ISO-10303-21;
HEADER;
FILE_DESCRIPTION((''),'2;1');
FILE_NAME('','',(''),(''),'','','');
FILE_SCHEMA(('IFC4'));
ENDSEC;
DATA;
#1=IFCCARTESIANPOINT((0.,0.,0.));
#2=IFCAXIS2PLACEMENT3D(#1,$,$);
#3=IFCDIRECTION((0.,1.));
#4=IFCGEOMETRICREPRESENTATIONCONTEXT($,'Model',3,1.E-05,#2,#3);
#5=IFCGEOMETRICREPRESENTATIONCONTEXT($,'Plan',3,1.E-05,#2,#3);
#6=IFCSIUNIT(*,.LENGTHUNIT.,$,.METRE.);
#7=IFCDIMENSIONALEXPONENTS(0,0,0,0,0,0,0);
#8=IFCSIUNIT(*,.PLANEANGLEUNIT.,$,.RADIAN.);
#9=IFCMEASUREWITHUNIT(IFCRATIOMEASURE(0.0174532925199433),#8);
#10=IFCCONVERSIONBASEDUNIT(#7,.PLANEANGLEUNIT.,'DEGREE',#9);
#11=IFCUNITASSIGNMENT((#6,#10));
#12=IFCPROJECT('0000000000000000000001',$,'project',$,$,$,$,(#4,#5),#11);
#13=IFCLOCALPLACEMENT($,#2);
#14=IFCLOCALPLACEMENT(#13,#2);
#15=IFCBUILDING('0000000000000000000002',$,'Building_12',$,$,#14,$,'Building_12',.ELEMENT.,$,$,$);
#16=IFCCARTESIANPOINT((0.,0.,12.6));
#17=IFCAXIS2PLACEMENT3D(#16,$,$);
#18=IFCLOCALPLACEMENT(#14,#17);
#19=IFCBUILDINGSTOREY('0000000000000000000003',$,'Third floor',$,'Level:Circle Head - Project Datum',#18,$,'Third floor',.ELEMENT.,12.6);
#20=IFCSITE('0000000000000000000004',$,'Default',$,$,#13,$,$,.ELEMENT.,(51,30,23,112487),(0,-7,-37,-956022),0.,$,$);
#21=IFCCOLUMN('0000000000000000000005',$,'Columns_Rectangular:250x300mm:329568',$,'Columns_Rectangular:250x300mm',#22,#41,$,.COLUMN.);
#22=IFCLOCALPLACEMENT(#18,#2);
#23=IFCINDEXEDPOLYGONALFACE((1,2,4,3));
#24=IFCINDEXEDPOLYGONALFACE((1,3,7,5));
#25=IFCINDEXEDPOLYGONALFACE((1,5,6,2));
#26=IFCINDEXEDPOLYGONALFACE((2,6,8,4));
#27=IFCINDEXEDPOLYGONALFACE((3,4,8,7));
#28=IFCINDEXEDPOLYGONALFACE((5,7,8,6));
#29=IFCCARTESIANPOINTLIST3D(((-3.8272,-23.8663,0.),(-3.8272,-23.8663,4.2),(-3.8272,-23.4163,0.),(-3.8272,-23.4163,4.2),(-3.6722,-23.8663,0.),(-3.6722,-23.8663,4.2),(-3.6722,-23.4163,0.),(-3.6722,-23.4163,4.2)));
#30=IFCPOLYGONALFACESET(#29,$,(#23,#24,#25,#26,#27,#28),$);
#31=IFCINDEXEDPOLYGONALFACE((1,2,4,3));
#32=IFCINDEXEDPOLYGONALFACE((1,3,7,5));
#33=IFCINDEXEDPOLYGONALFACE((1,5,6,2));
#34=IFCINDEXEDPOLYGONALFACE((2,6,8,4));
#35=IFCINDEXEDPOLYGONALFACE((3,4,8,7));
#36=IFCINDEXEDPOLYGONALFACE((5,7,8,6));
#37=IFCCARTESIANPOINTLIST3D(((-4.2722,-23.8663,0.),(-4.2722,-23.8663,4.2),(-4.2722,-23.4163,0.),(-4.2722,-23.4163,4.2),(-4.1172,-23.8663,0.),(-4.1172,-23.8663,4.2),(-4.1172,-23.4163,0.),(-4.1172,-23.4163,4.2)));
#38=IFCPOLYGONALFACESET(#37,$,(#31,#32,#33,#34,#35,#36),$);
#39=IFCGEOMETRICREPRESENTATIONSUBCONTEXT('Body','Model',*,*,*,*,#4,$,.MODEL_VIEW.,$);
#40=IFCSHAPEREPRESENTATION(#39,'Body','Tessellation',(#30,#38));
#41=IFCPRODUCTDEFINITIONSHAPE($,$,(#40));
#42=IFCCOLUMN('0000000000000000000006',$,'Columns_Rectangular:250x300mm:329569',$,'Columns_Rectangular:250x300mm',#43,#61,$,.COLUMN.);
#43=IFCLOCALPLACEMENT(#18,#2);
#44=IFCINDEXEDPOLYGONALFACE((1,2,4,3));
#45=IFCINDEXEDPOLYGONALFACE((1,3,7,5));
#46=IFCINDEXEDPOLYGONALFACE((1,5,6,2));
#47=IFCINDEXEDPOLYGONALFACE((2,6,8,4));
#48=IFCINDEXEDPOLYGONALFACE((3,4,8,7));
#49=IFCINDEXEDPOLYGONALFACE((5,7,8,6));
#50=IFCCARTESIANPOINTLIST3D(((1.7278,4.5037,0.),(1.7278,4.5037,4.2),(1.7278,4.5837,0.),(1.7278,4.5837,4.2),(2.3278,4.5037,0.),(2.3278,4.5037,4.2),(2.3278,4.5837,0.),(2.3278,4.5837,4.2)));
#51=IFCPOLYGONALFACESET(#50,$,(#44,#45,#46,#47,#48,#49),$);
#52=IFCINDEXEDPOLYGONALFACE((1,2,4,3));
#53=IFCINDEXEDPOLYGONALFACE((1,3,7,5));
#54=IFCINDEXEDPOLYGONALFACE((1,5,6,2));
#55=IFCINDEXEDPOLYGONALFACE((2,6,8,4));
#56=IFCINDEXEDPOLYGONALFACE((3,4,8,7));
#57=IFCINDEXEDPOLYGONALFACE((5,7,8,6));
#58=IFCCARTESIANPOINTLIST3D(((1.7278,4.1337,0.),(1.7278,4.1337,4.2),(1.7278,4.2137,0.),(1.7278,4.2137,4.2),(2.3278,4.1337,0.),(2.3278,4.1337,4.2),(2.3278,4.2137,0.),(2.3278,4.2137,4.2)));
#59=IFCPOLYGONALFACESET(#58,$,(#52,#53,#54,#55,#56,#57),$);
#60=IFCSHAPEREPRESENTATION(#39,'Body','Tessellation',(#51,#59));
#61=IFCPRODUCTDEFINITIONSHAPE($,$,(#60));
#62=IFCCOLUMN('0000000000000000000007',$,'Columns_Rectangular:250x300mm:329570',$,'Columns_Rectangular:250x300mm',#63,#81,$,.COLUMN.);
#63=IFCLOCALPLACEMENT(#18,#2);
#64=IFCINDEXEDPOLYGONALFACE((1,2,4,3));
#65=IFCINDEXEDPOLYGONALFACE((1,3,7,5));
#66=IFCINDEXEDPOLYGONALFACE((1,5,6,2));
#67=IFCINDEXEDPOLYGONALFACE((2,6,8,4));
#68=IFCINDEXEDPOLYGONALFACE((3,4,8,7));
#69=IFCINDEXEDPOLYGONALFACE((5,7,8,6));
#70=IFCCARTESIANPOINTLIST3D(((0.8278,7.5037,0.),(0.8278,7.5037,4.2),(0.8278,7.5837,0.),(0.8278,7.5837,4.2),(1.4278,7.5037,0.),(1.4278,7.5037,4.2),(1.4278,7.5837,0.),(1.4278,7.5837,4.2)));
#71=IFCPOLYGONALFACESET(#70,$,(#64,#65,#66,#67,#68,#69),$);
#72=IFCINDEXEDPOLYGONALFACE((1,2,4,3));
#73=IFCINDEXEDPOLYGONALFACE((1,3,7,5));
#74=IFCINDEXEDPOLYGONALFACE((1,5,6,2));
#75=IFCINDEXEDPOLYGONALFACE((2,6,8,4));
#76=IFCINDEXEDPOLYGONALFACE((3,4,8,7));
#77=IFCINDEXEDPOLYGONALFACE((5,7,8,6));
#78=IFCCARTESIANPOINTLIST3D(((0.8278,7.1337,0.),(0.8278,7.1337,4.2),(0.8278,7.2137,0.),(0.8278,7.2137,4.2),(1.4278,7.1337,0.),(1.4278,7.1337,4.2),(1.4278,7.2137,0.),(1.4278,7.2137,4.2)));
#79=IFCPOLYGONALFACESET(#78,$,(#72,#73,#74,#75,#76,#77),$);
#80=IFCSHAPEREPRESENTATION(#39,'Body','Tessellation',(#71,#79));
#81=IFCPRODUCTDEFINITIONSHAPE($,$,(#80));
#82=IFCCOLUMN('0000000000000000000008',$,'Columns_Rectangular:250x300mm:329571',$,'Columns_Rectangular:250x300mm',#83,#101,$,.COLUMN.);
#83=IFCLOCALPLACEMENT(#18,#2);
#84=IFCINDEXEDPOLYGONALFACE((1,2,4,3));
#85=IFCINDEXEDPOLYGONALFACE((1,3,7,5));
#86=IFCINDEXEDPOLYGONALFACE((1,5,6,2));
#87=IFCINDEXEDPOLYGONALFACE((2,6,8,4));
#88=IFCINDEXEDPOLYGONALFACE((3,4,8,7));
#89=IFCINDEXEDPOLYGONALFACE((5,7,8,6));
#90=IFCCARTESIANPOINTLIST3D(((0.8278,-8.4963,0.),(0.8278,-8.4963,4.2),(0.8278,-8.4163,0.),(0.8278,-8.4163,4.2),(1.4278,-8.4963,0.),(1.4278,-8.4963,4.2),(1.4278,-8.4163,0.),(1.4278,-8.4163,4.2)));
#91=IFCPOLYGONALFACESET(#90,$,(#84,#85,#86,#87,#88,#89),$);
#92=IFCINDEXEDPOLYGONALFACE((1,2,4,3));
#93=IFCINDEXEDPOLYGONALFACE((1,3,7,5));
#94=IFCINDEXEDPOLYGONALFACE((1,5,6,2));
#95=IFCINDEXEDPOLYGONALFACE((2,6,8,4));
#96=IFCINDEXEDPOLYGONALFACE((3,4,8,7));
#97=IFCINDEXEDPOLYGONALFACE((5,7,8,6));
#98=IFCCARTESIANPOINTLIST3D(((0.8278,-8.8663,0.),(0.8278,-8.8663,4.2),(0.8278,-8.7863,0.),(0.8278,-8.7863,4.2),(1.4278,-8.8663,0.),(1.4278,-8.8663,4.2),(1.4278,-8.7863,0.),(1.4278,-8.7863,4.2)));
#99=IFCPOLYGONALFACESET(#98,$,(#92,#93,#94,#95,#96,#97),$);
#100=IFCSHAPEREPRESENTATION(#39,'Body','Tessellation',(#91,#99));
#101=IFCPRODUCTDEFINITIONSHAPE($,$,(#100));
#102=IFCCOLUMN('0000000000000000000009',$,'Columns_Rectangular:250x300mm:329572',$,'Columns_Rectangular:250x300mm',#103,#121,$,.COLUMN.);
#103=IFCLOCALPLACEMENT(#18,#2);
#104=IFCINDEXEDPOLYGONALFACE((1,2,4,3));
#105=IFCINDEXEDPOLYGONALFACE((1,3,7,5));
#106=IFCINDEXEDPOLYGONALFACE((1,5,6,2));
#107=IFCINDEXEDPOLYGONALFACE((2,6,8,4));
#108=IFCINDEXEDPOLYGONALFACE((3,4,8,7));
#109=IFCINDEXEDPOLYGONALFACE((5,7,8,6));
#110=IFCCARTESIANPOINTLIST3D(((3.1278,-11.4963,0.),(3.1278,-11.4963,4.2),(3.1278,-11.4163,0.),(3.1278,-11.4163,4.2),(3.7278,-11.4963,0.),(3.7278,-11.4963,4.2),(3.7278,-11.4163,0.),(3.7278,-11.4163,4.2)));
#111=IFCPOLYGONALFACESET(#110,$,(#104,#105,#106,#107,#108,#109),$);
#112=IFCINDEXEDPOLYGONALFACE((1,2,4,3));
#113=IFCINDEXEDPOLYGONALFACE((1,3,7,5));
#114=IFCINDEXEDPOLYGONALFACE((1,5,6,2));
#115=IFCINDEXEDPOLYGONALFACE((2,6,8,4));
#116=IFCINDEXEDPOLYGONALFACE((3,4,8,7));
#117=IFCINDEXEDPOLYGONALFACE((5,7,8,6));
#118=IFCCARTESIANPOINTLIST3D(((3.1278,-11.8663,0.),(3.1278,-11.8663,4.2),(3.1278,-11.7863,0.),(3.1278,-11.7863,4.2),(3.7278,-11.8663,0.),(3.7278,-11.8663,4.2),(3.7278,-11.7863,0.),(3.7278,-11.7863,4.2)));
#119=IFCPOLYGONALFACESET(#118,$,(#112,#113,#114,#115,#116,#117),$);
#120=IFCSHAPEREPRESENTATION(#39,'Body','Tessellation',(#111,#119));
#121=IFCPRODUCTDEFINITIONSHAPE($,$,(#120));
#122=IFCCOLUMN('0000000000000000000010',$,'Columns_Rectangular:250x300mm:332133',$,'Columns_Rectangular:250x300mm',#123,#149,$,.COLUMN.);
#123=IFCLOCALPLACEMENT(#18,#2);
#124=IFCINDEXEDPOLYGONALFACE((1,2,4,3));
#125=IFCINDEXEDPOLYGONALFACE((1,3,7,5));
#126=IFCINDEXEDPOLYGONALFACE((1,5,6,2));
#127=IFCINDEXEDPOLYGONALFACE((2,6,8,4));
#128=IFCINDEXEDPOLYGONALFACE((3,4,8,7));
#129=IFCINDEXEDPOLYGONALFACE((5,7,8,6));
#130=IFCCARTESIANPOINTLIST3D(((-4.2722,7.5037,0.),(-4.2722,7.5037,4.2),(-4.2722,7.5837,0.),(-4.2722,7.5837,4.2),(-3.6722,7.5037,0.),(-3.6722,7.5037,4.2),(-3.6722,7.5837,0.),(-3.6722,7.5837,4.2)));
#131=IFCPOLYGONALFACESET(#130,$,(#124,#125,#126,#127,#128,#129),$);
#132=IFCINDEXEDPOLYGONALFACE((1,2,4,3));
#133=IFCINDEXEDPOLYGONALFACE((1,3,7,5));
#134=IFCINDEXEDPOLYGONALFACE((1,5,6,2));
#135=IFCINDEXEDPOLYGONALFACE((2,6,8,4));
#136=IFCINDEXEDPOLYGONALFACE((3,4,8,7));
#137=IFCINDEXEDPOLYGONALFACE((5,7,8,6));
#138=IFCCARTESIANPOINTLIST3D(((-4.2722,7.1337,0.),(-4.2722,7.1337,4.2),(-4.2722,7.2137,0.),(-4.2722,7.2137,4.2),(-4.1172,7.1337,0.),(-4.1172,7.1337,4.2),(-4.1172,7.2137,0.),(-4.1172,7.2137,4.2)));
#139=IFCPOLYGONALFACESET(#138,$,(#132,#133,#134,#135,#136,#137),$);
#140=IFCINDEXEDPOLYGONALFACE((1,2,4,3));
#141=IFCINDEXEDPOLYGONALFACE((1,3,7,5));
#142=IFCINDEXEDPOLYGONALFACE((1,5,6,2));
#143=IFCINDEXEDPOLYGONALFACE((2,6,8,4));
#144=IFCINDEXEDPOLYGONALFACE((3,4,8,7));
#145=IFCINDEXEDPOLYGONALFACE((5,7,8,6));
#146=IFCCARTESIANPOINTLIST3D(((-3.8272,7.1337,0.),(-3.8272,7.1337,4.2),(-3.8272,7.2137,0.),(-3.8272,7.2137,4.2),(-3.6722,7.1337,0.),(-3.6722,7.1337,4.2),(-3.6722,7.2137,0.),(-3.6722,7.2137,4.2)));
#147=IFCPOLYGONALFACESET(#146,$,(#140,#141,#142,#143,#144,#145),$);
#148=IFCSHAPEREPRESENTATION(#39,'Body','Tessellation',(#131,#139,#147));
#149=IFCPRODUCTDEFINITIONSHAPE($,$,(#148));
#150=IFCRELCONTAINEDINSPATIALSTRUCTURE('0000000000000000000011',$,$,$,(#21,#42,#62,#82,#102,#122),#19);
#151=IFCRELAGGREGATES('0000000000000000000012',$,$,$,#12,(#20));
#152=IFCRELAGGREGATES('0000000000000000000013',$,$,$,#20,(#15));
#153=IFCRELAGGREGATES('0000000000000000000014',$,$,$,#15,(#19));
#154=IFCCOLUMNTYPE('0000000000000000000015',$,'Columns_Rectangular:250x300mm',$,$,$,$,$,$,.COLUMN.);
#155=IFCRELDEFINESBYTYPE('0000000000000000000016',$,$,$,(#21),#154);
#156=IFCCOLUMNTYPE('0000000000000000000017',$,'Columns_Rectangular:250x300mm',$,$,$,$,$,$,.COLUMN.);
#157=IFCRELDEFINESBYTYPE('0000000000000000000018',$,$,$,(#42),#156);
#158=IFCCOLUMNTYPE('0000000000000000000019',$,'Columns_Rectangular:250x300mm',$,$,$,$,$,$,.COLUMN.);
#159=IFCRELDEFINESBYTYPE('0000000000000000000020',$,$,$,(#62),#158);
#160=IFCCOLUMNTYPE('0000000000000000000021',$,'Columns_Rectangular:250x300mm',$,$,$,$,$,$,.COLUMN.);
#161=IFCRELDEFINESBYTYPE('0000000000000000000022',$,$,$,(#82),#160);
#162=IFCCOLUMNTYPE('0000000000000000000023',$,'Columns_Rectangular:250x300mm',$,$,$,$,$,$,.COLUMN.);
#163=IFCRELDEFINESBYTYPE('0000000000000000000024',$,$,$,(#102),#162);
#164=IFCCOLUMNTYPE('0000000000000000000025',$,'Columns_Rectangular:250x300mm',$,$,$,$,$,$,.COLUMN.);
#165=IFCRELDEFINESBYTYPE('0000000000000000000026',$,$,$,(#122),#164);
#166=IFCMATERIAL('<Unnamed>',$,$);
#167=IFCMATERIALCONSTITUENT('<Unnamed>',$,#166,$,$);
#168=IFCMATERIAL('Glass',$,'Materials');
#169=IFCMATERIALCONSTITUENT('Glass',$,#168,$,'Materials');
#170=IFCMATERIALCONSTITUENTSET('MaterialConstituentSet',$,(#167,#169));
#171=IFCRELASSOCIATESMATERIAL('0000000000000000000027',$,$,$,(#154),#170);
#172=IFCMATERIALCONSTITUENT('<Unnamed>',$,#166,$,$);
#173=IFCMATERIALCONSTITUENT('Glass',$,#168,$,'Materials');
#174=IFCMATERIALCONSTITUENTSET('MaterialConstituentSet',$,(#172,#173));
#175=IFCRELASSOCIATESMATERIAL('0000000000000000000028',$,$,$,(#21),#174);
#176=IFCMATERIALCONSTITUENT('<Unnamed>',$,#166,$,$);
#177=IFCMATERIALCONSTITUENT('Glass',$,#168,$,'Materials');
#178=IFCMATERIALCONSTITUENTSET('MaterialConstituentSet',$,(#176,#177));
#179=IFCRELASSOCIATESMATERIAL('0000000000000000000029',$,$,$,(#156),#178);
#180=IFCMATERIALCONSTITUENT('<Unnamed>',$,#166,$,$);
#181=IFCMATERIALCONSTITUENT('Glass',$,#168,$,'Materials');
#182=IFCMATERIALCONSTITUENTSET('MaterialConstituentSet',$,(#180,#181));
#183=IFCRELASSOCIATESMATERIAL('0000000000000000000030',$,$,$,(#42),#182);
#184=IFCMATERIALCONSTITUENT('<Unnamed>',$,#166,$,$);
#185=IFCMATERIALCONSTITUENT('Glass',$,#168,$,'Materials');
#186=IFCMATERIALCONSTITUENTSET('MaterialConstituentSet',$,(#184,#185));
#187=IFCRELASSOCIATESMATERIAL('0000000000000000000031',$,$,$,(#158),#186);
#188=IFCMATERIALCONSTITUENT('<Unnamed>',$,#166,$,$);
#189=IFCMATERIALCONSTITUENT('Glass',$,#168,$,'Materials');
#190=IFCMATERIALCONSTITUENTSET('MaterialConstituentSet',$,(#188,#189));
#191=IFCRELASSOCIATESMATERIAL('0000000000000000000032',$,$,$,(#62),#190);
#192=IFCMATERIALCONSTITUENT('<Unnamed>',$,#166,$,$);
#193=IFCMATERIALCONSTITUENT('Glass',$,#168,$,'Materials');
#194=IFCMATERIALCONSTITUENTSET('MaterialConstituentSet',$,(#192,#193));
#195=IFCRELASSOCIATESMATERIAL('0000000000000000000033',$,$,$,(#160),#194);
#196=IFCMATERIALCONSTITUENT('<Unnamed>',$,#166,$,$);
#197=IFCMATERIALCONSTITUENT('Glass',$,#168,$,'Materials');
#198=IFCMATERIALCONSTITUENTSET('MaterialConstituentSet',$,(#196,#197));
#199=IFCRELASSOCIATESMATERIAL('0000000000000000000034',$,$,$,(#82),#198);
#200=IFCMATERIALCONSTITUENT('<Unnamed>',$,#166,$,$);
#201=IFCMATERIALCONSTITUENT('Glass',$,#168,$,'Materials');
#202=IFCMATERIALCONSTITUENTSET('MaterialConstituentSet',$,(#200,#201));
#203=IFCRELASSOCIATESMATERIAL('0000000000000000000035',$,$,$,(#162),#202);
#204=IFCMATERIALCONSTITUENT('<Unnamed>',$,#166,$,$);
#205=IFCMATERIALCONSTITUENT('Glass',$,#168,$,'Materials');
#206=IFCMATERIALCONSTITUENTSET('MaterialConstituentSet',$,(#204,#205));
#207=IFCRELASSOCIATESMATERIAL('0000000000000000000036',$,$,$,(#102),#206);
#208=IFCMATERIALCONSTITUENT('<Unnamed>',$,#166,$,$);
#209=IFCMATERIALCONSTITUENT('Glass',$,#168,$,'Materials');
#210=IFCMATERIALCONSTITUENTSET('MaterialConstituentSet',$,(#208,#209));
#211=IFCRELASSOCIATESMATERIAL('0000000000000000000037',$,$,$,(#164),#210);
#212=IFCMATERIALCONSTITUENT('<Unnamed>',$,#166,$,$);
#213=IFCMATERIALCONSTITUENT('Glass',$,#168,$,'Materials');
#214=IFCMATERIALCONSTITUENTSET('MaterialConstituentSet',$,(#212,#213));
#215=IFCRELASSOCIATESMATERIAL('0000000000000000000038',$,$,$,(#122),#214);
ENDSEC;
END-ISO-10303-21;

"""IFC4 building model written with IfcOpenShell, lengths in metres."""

from ifc_helpers import new_model, entity, si_unit, converted_unit, direction, frame, origin, place, context, subcontext, project, spatial, indexed_curve, outline, extrude, source, transform, mapped, material, constituent, constituent_set, type_object, type_shapes, element, save


model = new_model("IFC4")

# Units and contexts
model_context = context("Model", 3, precision=1e-05, world=origin(), true_north=direction((0.0, 1.0)))
plan_context = context("Plan", 3, precision=1e-05, world=origin(), true_north=direction((0.0, 1.0)))
body_context = subcontext(model_context, "Body", "Model", "MODEL_VIEW")
ifc_project = project(units=[si_unit("LENGTHUNIT", "METRE"), converted_unit("PLANEANGLEUNIT", "DEGREE", entity("IfcRatioMeasure", 0.0174532925199433), si_unit("PLANEANGLEUNIT", "RADIAN"), dimensions=[0, 0, 0, 0, 0, 0, 0])], contexts=[model_context, plan_context])

# Site, building, storey
site_placement = place(None, origin())
site = spatial("IfcSite", under=ifc_project, at=site_placement, Name="Default", CompositionType="ELEMENT", RefLatitude=(51, 30, 23, 112487), RefLongitude=(0, -7, -37, -956022), RefElevation=0.0)
building_placement = place(site_placement, origin())
building = spatial("IfcBuilding", under=site, at=building_placement, Name="Building_12", LongName="Building_12", CompositionType="ELEMENT")
storey_placement = place(building_placement, frame((0.0, 0.0, 12.6)))
storey = spatial("IfcBuildingStorey", under=building, at=storey_placement, Name="Third floor", ObjectType="Level:Circle Head - Project Datum", LongName="Third floor", CompositionType="ELEMENT", Elevation=12.6)

# Columns
ifc_material_1 = material(Name="<Unnamed>")
ifc_material_2 = material(Name="Glass", Category="Materials")
ifc_constituent_1 = constituent(ifc_material_1, Name="<Unnamed>")
ifc_constituent_2 = constituent(ifc_material_2, Name="Glass", Category="Materials")
ifc_constituent_set_1 = constituent_set(constituents=[ifc_constituent_1, ifc_constituent_2], Name="MaterialConstituentSet")
ifc_constituent_3 = constituent(ifc_material_1, Name="<Unnamed>")
ifc_constituent_4 = constituent(ifc_material_2, Name="Glass", Category="Materials")
ifc_constituent_set_2 = constituent_set(constituents=[ifc_constituent_3, ifc_constituent_4], Name="MaterialConstituentSet")
column_type_1 = type_object("IfcColumnType", Name="Columns_Rectangular:250x300mm", PredefinedType="COLUMN", material=ifc_constituent_set_2)
shared_shape_1 = source(origin(), body_context, "Body", "SweptSolid", [
    extrude(outline(indexed_curve([(-0.225, -0.0775), (0.225, -0.0775), (0.225, 0.0775), (-0.225, 0.0775), (-0.225, -0.0775)], self_intersect=False)), frame((-3.7497, -23.6413, 12.6), z_axis=(0.0, 0.0, 1.0), x_axis=(0.0, -1.0, 0.0)), (0.0, 0.0, 1.0), 4.2),
    extrude(outline(indexed_curve([(-0.225, -0.0775), (0.225, -0.0775), (0.225, 0.0775), (-0.225, 0.0775), (-0.225, -0.0775)], self_intersect=False)), frame((-4.1947, -23.6413, 12.6), z_axis=(0.0, 0.0, 1.0), x_axis=(0.0, -1.0, 0.0)), (0.0, 0.0, 1.0), 4.2),
])
type_shapes(column_type_1, [shared_shape_1])
column_1_placement = place(storey_placement, frame((0.0, 0.0, -12.6)))
element("IfcColumn", 1, at=column_1_placement, inside=storey, type_object=column_type_1, material=ifc_constituent_set_1, Name="Columns_Rectangular:250x300mm:329568", ObjectType="Columns_Rectangular:250x300mm", PredefinedType="COLUMN", context=body_context, shape_type="MappedRepresentation", body=[
    mapped(shared_shape_1, transform((0.0, 0.0, 0.0), scale=1.0)),
])
ifc_constituent_5 = constituent(ifc_material_1, Name="<Unnamed>")
ifc_constituent_6 = constituent(ifc_material_2, Name="Glass", Category="Materials")
ifc_constituent_set_3 = constituent_set(constituents=[ifc_constituent_5, ifc_constituent_6], Name="MaterialConstituentSet")
ifc_constituent_7 = constituent(ifc_material_1, Name="<Unnamed>")
ifc_constituent_8 = constituent(ifc_material_2, Name="Glass", Category="Materials")
ifc_constituent_set_4 = constituent_set(constituents=[ifc_constituent_7, ifc_constituent_8], Name="MaterialConstituentSet")
column_type_2 = type_object("IfcColumnType", Name="Columns_Rectangular:250x300mm", PredefinedType="COLUMN", material=ifc_constituent_set_4)
shared_shape_2 = source(origin(), body_context, "Body", "SweptSolid", [
    extrude(outline(indexed_curve([(-0.04, -0.3), (0.04, -0.3), (0.04, 0.3), (-0.04, 0.3), (-0.04, -0.3)], self_intersect=False)), frame((2.0278, 4.5437, 12.6), z_axis=(0.0, 0.0, 1.0), x_axis=(0.0, -1.0, 0.0)), (0.0, 0.0, 1.0), 4.2),
    extrude(outline(indexed_curve([(-0.04, -0.3), (0.04, -0.3), (0.04, 0.3), (-0.04, 0.3), (-0.04, -0.3)], self_intersect=False)), frame((2.0278, 4.1737, 12.6), z_axis=(0.0, 0.0, 1.0), x_axis=(0.0, -1.0, 0.0)), (0.0, 0.0, 1.0), 4.2),
])
type_shapes(column_type_2, [shared_shape_2])
column_2_placement = place(storey_placement, frame((0.0, 0.0, -12.6)))
element("IfcColumn", 2, at=column_2_placement, inside=storey, type_object=column_type_2, material=ifc_constituent_set_3, Name="Columns_Rectangular:250x300mm:329569", ObjectType="Columns_Rectangular:250x300mm", PredefinedType="COLUMN", context=body_context, shape_type="MappedRepresentation", body=[
    mapped(shared_shape_2, transform((0.0, 0.0, 0.0), scale=1.0)),
])
ifc_constituent_9 = constituent(ifc_material_1, Name="<Unnamed>")
ifc_constituent_10 = constituent(ifc_material_2, Name="Glass", Category="Materials")
ifc_constituent_set_5 = constituent_set(constituents=[ifc_constituent_9, ifc_constituent_10], Name="MaterialConstituentSet")
ifc_constituent_11 = constituent(ifc_material_1, Name="<Unnamed>")
ifc_constituent_12 = constituent(ifc_material_2, Name="Glass", Category="Materials")
ifc_constituent_set_6 = constituent_set(constituents=[ifc_constituent_11, ifc_constituent_12], Name="MaterialConstituentSet")
column_type_3 = type_object("IfcColumnType", Name="Columns_Rectangular:250x300mm", PredefinedType="COLUMN", material=ifc_constituent_set_6)
shared_shape_3 = source(origin(), body_context, "Body", "SweptSolid", [
    extrude(outline(indexed_curve([(-0.04, -0.3), (0.04, -0.3), (0.04, 0.3), (-0.04, 0.3), (-0.04, -0.3)], self_intersect=False)), frame((1.1278, 7.5437, 12.6), z_axis=(0.0, 0.0, 1.0), x_axis=(0.0, -1.0, 0.0)), (0.0, 0.0, 1.0), 4.2),
    extrude(outline(indexed_curve([(-0.04, -0.3), (0.04, -0.3), (0.04, 0.3), (-0.04, 0.3), (-0.04, -0.3)], self_intersect=False)), frame((1.1278, 7.1737, 12.6), z_axis=(0.0, 0.0, 1.0), x_axis=(0.0, -1.0, 0.0)), (0.0, 0.0, 1.0), 4.2),
])
type_shapes(column_type_3, [shared_shape_3])
column_3_placement = place(storey_placement, frame((0.0, 0.0, -12.6)))
element("IfcColumn", 3, at=column_3_placement, inside=storey, type_object=column_type_3, material=ifc_constituent_set_5, Name="Columns_Rectangular:250x300mm:329570", ObjectType="Columns_Rectangular:250x300mm", PredefinedType="COLUMN", context=body_context, shape_type="MappedRepresentation", body=[
    mapped(shared_shape_3, transform((0.0, 0.0, 0.0), scale=1.0)),
])
ifc_constituent_13 = constituent(ifc_material_1, Name="<Unnamed>")
ifc_constituent_14 = constituent(ifc_material_2, Name="Glass", Category="Materials")
ifc_constituent_set_7 = constituent_set(constituents=[ifc_constituent_13, ifc_constituent_14], Name="MaterialConstituentSet")
ifc_constituent_15 = constituent(ifc_material_1, Name="<Unnamed>")
ifc_constituent_16 = constituent(ifc_material_2, Name="Glass", Category="Materials")
ifc_constituent_set_8 = constituent_set(constituents=[ifc_constituent_15, ifc_constituent_16], Name="MaterialConstituentSet")
column_type_4 = type_object("IfcColumnType", Name="Columns_Rectangular:250x300mm", PredefinedType="COLUMN", material=ifc_constituent_set_8)
shared_shape_4 = source(origin(), body_context, "Body", "SweptSolid", [
    extrude(outline(indexed_curve([(-0.04, -0.3), (0.04, -0.3), (0.04, 0.3), (-0.04, 0.3), (-0.04, -0.3)], self_intersect=False)), frame((1.1278, -8.4563, 12.6), z_axis=(0.0, 0.0, 1.0), x_axis=(0.0, -1.0, 0.0)), (0.0, 0.0, 1.0), 4.2),
    extrude(outline(indexed_curve([(-0.04, -0.3), (0.04, -0.3), (0.04, 0.3), (-0.04, 0.3), (-0.04, -0.3)], self_intersect=False)), frame((1.1278, -8.8263, 12.6), z_axis=(0.0, 0.0, 1.0), x_axis=(0.0, -1.0, 0.0)), (0.0, 0.0, 1.0), 4.2),
])
type_shapes(column_type_4, [shared_shape_4])
column_4_placement = place(storey_placement, frame((0.0, 0.0, -12.6)))
element("IfcColumn", 4, at=column_4_placement, inside=storey, type_object=column_type_4, material=ifc_constituent_set_7, Name="Columns_Rectangular:250x300mm:329571", ObjectType="Columns_Rectangular:250x300mm", PredefinedType="COLUMN", context=body_context, shape_type="MappedRepresentation", body=[
    mapped(shared_shape_4, transform((0.0, 0.0, 0.0), scale=1.0)),
])
ifc_constituent_17 = constituent(ifc_material_1, Name="<Unnamed>")
ifc_constituent_18 = constituent(ifc_material_2, Name="Glass", Category="Materials")
ifc_constituent_set_9 = constituent_set(constituents=[ifc_constituent_17, ifc_constituent_18], Name="MaterialConstituentSet")
ifc_constituent_19 = constituent(ifc_material_1, Name="<Unnamed>")
ifc_constituent_20 = constituent(ifc_material_2, Name="Glass", Category="Materials")
ifc_constituent_set_10 = constituent_set(constituents=[ifc_constituent_19, ifc_constituent_20], Name="MaterialConstituentSet")
column_type_5 = type_object("IfcColumnType", Name="Columns_Rectangular:250x300mm", PredefinedType="COLUMN", material=ifc_constituent_set_10)
shared_shape_5 = source(origin(), body_context, "Body", "SweptSolid", [
    extrude(outline(indexed_curve([(-0.04, -0.3), (0.04, -0.3), (0.04, 0.3), (-0.04, 0.3), (-0.04, -0.3)], self_intersect=False)), frame((3.4278, -11.4563, 12.6), z_axis=(0.0, 0.0, 1.0), x_axis=(0.0, -1.0, 0.0)), (0.0, 0.0, 1.0), 4.2),
    extrude(outline(indexed_curve([(-0.04, -0.3), (0.04, -0.3), (0.04, 0.3), (-0.04, 0.3), (-0.04, -0.3)], self_intersect=False)), frame((3.4278, -11.8263, 12.6), z_axis=(0.0, 0.0, 1.0), x_axis=(0.0, -1.0, 0.0)), (0.0, 0.0, 1.0), 4.2),
])
type_shapes(column_type_5, [shared_shape_5])
column_5_placement = place(storey_placement, frame((0.0, 0.0, -12.6)))
element("IfcColumn", 5, at=column_5_placement, inside=storey, type_object=column_type_5, material=ifc_constituent_set_9, Name="Columns_Rectangular:250x300mm:329572", ObjectType="Columns_Rectangular:250x300mm", PredefinedType="COLUMN", context=body_context, shape_type="MappedRepresentation", body=[
    mapped(shared_shape_5, transform((0.0, 0.0, 0.0), scale=1.0)),
])
ifc_constituent_21 = constituent(ifc_material_1, Name="<Unnamed>")
ifc_constituent_22 = constituent(ifc_material_2, Name="Glass", Category="Materials")
ifc_constituent_set_11 = constituent_set(constituents=[ifc_constituent_21, ifc_constituent_22], Name="MaterialConstituentSet")
ifc_constituent_23 = constituent(ifc_material_1, Name="<Unnamed>")
ifc_constituent_24 = constituent(ifc_material_2, Name="Glass", Category="Materials")
ifc_constituent_set_12 = constituent_set(constituents=[ifc_constituent_23, ifc_constituent_24], Name="MaterialConstituentSet")
column_type_6 = type_object("IfcColumnType", Name="Columns_Rectangular:250x300mm", PredefinedType="COLUMN", material=ifc_constituent_set_12)
shared_shape_6 = source(origin(), body_context, "Body", "SweptSolid", [
    extrude(outline(indexed_curve([(-0.04, -0.3), (0.04, -0.3), (0.04, 0.3), (-0.04, 0.3), (-0.04, -0.3)], self_intersect=False)), frame((-3.9722, 7.5437, 12.6), z_axis=(0.0, 0.0, 1.0), x_axis=(0.0, -1.0, 0.0)), (0.0, 0.0, 1.0), 4.2),
    extrude(outline(indexed_curve([(-0.04, -0.0775), (0.04, -0.0775), (0.04, 0.0775), (-0.04, 0.0775), (-0.04, -0.0775)], self_intersect=False)), frame((-4.1947, 7.1737, 12.6), z_axis=(0.0, 0.0, 1.0), x_axis=(0.0, -1.0, 0.0)), (0.0, 0.0, 1.0), 4.2),
    extrude(outline(indexed_curve([(-0.04, -0.0775), (0.04, -0.0775), (0.04, 0.0775), (-0.04, 0.0775), (-0.04, -0.0775)], self_intersect=False)), frame((-3.7497, 7.1737, 12.6), z_axis=(0.0, 0.0, 1.0), x_axis=(0.0, -1.0, 0.0)), (0.0, 0.0, 1.0), 4.2),
])
type_shapes(column_type_6, [shared_shape_6])
column_6_placement = place(storey_placement, frame((0.0, 0.0, -12.6)))
element("IfcColumn", 6, at=column_6_placement, inside=storey, type_object=column_type_6, material=ifc_constituent_set_11, Name="Columns_Rectangular:250x300mm:332133", ObjectType="Columns_Rectangular:250x300mm", PredefinedType="COLUMN", context=body_context, shape_type="MappedRepresentation", body=[
    mapped(shared_shape_6, transform((0.0, 0.0, 0.0), scale=1.0)),
])

save(model, "model.ifc")
